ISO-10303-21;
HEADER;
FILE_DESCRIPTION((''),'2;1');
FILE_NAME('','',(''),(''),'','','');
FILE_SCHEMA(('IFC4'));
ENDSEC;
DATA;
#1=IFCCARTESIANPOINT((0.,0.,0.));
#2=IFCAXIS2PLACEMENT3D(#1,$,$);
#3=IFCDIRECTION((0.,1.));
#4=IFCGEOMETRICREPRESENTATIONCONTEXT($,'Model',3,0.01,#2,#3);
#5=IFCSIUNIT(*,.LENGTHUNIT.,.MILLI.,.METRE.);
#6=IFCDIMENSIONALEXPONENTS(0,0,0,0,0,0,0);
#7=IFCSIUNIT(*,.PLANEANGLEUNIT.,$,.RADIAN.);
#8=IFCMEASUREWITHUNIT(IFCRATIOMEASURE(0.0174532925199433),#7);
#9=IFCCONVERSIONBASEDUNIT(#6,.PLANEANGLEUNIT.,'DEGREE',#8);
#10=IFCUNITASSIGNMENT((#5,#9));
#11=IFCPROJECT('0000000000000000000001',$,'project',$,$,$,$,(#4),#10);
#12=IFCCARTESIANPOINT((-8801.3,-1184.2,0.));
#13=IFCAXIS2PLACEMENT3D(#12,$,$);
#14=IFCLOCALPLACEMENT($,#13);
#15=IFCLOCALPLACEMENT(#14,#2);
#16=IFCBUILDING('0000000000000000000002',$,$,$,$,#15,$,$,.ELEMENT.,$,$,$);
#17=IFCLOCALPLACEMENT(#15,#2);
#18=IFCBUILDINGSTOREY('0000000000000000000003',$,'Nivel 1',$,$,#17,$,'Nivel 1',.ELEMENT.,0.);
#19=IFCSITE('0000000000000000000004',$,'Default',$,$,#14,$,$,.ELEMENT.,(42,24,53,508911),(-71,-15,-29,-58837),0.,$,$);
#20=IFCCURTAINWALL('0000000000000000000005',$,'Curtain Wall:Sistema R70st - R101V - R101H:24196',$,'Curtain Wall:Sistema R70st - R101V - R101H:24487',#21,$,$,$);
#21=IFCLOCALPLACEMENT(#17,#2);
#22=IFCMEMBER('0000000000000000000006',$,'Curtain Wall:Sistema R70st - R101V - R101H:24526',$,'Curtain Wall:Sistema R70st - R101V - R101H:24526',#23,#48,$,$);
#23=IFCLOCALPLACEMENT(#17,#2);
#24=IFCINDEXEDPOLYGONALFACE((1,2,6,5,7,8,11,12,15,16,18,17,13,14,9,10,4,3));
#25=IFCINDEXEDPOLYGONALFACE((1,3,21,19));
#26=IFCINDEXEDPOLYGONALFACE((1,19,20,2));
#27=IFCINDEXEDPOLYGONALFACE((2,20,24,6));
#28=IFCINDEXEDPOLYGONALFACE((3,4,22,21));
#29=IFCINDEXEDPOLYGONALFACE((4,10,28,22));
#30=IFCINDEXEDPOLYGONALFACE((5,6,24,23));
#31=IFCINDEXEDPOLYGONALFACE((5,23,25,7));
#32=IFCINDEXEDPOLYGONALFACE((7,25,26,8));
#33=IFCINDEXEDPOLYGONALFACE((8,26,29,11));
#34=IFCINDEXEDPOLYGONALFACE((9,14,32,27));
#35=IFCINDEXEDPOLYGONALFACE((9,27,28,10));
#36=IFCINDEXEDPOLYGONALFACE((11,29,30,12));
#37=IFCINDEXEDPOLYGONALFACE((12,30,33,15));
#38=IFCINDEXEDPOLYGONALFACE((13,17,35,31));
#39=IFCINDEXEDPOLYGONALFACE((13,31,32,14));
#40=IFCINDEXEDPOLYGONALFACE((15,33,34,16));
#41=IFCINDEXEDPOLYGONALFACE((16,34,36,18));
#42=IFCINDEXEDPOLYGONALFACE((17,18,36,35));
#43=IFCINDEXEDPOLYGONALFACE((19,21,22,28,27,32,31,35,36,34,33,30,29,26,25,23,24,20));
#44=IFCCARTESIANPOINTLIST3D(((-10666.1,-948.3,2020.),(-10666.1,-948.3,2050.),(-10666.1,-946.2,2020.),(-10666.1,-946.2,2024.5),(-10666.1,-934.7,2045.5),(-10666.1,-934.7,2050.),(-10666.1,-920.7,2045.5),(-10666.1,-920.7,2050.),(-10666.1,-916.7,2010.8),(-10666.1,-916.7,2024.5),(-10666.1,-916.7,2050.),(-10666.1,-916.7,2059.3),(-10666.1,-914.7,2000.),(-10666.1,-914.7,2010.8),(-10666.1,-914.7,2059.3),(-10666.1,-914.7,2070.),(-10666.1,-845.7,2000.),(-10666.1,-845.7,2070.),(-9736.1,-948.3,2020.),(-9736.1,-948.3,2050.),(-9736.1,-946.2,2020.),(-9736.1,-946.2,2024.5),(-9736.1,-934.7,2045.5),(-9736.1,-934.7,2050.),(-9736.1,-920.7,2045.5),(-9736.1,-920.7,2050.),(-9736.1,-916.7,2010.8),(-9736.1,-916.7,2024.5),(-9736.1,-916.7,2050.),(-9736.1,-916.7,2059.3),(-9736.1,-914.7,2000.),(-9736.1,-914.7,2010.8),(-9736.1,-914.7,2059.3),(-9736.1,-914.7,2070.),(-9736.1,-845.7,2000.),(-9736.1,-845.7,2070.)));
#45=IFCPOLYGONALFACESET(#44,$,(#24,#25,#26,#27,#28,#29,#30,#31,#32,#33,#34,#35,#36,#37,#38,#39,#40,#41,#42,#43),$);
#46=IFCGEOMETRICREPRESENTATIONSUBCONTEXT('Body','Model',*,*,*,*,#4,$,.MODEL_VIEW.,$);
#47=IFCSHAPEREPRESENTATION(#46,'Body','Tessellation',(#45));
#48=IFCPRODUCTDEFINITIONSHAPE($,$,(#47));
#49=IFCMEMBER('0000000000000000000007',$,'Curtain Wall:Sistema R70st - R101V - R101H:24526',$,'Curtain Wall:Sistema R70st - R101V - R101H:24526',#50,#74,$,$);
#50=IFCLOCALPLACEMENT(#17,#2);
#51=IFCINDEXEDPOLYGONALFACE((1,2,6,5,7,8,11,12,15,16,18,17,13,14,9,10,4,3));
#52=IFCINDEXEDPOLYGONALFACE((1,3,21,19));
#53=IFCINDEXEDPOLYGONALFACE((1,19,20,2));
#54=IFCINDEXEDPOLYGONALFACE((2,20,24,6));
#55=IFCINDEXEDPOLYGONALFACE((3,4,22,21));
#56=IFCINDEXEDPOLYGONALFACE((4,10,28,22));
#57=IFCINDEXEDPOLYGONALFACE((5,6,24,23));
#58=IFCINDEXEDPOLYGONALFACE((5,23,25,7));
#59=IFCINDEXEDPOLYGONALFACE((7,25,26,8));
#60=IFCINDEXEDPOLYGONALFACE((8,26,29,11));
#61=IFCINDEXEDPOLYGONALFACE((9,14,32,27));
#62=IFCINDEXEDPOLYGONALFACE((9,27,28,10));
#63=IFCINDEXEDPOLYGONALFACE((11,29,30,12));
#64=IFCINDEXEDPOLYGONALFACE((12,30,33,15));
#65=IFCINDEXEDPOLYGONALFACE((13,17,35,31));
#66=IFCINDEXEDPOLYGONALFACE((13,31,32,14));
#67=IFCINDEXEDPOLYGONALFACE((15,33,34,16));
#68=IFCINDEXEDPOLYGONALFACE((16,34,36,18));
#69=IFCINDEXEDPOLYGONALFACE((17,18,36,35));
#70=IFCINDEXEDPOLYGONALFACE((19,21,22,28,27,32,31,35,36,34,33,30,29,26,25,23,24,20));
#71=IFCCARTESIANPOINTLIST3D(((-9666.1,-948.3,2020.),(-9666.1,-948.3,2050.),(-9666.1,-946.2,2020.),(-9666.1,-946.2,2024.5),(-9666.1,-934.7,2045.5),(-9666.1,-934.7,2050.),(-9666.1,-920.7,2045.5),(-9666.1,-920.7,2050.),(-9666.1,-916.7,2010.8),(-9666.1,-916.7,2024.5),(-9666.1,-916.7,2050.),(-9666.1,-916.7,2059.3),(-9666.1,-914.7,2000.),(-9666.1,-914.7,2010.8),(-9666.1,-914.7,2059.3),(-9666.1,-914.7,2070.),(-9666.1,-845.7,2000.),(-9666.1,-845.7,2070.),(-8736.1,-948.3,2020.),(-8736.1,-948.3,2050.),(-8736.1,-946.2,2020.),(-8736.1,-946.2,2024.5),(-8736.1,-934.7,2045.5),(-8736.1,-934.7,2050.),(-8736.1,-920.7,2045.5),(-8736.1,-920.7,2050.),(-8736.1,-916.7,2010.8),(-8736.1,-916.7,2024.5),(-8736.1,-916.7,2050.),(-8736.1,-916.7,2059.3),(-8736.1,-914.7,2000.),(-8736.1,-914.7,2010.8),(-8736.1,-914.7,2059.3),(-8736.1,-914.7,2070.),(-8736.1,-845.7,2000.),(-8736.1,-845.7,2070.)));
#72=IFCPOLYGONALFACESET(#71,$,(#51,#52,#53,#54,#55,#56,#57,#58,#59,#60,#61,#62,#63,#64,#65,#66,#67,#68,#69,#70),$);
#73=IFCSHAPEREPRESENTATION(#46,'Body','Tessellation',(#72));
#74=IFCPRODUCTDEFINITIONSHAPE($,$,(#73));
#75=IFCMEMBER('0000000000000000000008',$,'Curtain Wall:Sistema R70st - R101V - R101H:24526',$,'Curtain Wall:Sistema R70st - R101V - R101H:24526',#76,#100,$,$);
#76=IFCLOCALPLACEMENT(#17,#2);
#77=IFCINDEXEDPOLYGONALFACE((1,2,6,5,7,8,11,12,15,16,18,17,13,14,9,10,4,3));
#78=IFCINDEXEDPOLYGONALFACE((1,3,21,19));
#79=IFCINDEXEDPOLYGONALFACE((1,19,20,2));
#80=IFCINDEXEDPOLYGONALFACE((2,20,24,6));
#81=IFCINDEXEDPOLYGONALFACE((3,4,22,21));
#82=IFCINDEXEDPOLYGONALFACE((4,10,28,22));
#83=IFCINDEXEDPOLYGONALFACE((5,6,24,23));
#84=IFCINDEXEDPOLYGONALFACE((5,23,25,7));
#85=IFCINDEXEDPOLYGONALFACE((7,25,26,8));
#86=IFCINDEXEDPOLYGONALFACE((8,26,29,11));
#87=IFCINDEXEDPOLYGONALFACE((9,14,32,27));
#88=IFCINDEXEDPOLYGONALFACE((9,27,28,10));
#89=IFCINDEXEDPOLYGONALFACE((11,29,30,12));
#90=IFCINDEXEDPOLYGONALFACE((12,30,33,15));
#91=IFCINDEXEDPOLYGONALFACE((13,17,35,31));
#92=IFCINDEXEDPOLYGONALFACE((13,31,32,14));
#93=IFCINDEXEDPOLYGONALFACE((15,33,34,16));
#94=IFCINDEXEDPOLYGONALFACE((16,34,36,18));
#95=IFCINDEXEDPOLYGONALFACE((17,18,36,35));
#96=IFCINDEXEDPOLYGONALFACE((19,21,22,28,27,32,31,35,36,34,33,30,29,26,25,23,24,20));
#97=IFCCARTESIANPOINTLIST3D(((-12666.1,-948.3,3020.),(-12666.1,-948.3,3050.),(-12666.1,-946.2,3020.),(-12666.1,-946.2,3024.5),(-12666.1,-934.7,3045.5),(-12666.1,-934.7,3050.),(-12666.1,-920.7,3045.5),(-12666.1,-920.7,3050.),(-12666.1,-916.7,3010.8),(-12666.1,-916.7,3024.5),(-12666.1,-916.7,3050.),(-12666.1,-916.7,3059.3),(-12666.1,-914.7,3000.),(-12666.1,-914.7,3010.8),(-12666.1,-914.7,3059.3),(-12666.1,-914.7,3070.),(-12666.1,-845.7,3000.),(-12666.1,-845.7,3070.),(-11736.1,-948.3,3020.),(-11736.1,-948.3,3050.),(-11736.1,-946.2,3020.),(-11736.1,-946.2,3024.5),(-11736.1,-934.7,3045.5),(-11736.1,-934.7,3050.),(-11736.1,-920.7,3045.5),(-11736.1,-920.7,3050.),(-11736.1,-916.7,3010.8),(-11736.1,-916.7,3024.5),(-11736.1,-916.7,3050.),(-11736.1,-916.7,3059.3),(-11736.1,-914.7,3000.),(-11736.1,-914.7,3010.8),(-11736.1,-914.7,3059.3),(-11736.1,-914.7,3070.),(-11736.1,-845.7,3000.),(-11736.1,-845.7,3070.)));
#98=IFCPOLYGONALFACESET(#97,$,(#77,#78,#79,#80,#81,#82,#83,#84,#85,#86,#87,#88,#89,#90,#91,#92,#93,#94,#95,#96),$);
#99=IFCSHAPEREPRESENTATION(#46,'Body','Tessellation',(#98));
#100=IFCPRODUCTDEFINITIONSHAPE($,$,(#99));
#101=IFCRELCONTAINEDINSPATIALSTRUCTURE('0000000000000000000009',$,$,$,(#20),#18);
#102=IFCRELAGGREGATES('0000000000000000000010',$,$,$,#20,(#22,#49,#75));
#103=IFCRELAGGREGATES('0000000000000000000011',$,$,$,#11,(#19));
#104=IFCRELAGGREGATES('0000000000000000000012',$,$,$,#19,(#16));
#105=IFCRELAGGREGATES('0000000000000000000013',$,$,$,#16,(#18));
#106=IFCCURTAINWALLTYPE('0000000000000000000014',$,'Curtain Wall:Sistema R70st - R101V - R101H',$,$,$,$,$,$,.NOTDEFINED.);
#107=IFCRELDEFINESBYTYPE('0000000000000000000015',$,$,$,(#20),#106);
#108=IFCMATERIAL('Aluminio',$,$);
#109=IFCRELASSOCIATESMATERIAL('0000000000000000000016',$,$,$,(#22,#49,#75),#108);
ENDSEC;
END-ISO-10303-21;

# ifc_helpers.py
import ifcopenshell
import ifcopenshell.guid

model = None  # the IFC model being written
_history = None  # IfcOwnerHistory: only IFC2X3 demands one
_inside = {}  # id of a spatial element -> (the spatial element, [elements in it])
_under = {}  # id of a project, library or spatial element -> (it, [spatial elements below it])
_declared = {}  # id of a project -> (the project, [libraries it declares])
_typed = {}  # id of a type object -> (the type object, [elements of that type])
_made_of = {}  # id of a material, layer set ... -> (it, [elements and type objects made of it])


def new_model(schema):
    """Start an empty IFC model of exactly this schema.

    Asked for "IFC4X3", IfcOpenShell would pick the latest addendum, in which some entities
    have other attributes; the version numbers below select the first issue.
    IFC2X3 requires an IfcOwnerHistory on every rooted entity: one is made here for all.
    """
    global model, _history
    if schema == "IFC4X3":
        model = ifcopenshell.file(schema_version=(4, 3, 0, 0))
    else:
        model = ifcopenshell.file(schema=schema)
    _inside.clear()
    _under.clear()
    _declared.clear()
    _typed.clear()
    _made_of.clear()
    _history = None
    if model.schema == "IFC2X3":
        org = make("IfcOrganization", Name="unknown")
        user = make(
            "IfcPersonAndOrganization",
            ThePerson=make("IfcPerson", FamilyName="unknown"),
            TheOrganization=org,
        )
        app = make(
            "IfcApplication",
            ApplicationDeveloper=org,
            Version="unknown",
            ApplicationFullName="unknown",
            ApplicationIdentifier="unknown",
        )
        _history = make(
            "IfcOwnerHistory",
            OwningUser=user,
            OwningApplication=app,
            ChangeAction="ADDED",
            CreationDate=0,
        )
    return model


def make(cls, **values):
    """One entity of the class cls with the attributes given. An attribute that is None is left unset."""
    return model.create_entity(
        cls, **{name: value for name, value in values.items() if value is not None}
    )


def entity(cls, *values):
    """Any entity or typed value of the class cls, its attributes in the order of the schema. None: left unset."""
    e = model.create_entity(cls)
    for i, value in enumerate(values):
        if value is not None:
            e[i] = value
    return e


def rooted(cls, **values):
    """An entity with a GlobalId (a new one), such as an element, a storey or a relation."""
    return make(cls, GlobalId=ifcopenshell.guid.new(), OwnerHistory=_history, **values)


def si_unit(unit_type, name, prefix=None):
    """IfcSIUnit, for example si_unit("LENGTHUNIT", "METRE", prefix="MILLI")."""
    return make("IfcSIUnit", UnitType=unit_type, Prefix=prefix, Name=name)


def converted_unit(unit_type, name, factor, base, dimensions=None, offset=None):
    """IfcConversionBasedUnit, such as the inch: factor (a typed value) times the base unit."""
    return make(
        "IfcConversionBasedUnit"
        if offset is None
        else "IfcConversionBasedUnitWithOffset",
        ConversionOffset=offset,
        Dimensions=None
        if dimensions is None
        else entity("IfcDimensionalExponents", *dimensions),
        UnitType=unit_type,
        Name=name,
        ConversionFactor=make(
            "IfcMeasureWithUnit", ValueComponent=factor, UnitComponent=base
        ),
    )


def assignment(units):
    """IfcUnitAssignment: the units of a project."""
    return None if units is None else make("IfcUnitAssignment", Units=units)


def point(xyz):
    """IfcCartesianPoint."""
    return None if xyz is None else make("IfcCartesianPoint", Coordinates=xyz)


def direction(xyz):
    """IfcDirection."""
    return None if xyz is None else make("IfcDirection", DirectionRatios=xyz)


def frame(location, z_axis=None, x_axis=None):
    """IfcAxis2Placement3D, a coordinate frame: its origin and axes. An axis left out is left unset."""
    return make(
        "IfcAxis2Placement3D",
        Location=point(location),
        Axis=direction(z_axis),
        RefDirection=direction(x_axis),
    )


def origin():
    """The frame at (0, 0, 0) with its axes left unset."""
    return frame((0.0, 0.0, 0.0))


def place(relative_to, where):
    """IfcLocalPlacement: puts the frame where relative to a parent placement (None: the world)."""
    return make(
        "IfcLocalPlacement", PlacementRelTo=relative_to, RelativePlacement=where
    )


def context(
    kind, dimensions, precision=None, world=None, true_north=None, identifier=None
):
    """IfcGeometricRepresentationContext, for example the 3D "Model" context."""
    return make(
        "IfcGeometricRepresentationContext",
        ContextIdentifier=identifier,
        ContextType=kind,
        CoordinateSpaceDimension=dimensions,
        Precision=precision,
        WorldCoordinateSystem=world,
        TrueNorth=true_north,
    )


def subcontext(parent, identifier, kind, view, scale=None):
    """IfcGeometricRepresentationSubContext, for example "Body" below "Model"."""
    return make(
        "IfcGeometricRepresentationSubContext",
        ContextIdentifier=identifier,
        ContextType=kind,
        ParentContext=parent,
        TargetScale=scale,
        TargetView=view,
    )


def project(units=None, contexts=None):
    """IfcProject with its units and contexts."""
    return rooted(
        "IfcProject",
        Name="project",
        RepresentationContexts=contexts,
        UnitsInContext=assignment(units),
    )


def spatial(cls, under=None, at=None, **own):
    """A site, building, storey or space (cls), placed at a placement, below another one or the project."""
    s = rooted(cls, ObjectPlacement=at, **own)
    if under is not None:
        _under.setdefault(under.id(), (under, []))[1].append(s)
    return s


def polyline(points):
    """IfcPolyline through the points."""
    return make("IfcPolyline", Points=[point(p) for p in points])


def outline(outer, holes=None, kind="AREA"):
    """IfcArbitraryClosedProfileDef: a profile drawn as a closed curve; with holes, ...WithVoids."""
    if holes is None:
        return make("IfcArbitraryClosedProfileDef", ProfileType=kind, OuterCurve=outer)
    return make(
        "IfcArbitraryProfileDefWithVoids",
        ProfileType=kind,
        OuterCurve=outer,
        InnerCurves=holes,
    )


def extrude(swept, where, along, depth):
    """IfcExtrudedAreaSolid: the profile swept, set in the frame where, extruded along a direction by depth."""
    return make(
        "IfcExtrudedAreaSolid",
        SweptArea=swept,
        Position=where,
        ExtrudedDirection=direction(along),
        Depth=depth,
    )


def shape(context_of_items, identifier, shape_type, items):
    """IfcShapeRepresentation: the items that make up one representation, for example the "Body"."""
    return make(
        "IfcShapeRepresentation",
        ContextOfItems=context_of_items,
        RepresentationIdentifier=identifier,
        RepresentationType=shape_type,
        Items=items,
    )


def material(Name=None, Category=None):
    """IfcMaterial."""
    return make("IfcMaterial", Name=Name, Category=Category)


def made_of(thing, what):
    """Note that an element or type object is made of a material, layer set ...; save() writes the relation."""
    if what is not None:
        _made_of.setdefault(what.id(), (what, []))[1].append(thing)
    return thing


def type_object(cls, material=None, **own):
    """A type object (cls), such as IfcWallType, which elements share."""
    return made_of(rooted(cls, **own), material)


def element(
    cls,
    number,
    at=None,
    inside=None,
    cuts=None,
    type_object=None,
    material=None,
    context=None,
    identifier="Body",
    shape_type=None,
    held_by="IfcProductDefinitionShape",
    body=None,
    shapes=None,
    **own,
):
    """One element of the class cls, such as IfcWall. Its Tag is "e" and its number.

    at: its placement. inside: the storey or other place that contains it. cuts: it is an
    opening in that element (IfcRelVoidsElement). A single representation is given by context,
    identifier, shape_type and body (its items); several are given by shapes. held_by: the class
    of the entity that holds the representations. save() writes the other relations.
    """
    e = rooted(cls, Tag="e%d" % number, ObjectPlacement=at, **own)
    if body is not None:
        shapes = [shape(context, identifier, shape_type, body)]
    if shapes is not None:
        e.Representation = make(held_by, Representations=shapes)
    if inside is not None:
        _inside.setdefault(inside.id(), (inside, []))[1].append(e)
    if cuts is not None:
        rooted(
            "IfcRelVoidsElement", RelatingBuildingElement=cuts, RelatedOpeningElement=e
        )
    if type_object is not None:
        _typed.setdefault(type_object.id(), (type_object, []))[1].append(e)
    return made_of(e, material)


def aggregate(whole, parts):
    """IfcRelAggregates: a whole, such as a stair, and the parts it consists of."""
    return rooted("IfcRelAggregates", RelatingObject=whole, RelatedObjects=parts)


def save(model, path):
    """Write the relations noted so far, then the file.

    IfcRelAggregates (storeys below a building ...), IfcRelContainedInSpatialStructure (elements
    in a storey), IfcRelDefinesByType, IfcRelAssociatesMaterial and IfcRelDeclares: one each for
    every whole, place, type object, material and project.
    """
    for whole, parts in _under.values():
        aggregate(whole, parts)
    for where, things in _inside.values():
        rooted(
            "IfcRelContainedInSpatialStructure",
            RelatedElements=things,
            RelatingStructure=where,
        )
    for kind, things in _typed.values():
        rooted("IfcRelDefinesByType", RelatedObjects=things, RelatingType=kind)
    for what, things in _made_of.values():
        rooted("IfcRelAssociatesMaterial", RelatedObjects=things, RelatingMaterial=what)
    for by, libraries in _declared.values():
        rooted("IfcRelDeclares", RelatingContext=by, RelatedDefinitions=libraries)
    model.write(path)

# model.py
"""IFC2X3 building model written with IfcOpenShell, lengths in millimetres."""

from ifc_helpers import new_model, entity, si_unit, converted_unit, direction, frame, origin, place, context, subcontext, project, spatial, polyline, outline, extrude, material, type_object, element, aggregate, save


model = new_model("IFC2X3")

# Units and contexts
model_context = context("Model", 3, precision=0.01, world=origin(), true_north=direction((0.0, 1.0)))
body_context = subcontext(model_context, "Body", "Model", "MODEL_VIEW")
ifc_project = project(units=[si_unit("LENGTHUNIT", "METRE", prefix="MILLI"), converted_unit("PLANEANGLEUNIT", "DEGREE", entity("IfcRatioMeasure", 0.0174532925199433), si_unit("PLANEANGLEUNIT", "RADIAN"), dimensions=[0, 0, 0, 0, 0, 0, 0])], contexts=[model_context])

# Site, building, storey
site_placement = place(None, frame((-8801.3, -1184.2, 0.0)))
site = spatial("IfcSite", under=ifc_project, at=site_placement, Name="Default", CompositionType="ELEMENT", RefLatitude=(42, 24, 53, 508911), RefLongitude=(-71, -15, -29, -58837), RefElevation=0.0)
building_placement = place(site_placement, origin())
building = spatial("IfcBuilding", under=site, at=building_placement, CompositionType="ELEMENT")
storey_placement = place(building_placement, origin())
storey = spatial("IfcBuildingStorey", under=building, at=storey_placement, Name="Nivel 1", LongName="Nivel 1", CompositionType="ELEMENT", Elevation=0.0)

# Curtain wall, members
curtain_wall_type = type_object("IfcCurtainWallType", Name="Curtain Wall:Sistema R70st - R101V - R101H", PredefinedType="NOTDEFINED")
curtain_wall_placement = place(storey_placement, origin())
curtain_wall = element("IfcCurtainWall", 1, at=curtain_wall_placement, inside=storey, type_object=curtain_wall_type, Name="Curtain Wall:Sistema R70st - R101V - R101H:24196", ObjectType="Curtain Wall:Sistema R70st - R101V - R101H:24487")
ifc_material = material(Name="Aluminio")
member_1_placement = place(curtain_wall_placement, origin())
member_1 = element("IfcMember", 2, at=member_1_placement, material=ifc_material, Name="Curtain Wall:Sistema R70st - R101V - R101H:24526", ObjectType="Curtain Wall:Sistema R70st - R101V - R101H:24526", context=body_context, shape_type="SweptSolid", body=[
    extrude(outline(polyline([(-33.3, -71.9), (36.7, -71.9), (36.7, -2.9), (25.9, -2.9), (25.9, -0.9), (12.2, -0.9), (12.2, 28.6), (16.7, 28.6), (16.7, 30.7), (-13.3, 30.7), (-13.3, 17.1), (-8.8, 17.1), (-8.8, 3.1), (-13.3, 3.1), (-13.3, -0.9), (-22.6, -0.9), (-22.6, -2.9), (-33.3, -2.9), (-33.3, -71.9)])), frame((-9736.1, -917.6, 2036.7), z_axis=(-1.0, 0.0, 0.0), x_axis=(0.0, 0.0, -1.0)), (0.0, 0.0, 1.0), 930.0),
])
member_2_placement = place(curtain_wall_placement, origin())
member_2 = element("IfcMember", 3, at=member_2_placement, material=ifc_material, Name="Curtain Wall:Sistema R70st - R101V - R101H:24526", ObjectType="Curtain Wall:Sistema R70st - R101V - R101H:24526", context=body_context, shape_type="SweptSolid", body=[
    extrude(outline(polyline([(-33.3, -71.9), (36.7, -71.9), (36.7, -2.9), (25.9, -2.9), (25.9, -0.9), (12.2, -0.9), (12.2, 28.6), (16.7, 28.6), (16.7, 30.7), (-13.3, 30.7), (-13.3, 17.1), (-8.8, 17.1), (-8.8, 3.1), (-13.3, 3.1), (-13.3, -0.9), (-22.6, -0.9), (-22.6, -2.9), (-33.3, -2.9), (-33.3, -71.9)])), frame((-8736.1, -917.6, 2036.7), z_axis=(-1.0, 0.0, 0.0), x_axis=(0.0, 0.0, -1.0)), (0.0, 0.0, 1.0), 930.0),
])
member_3_placement = place(curtain_wall_placement, origin())
member_3 = element("IfcMember", 4, at=member_3_placement, material=ifc_material, Name="Curtain Wall:Sistema R70st - R101V - R101H:24526", ObjectType="Curtain Wall:Sistema R70st - R101V - R101H:24526", context=body_context, shape_type="SweptSolid", body=[
    extrude(outline(polyline([(-33.3, -71.9), (36.7, -71.9), (36.7, -2.9), (25.9, -2.9), (25.9, -0.9), (12.2, -0.9), (12.2, 28.6), (16.7, 28.6), (16.7, 30.7), (-13.3, 30.7), (-13.3, 17.1), (-8.8, 17.1), (-8.8, 3.1), (-13.3, 3.1), (-13.3, -0.9), (-22.6, -0.9), (-22.6, -2.9), (-33.3, -2.9), (-33.3, -71.9)])), frame((-11736.1, -917.6, 3036.7), z_axis=(-1.0, 0.0, 0.0), x_axis=(0.0, 0.0, -1.0)), (0.0, 0.0, 1.0), 930.0),
])
aggregate(curtain_wall, [member_1, member_2, member_3])

save(model, "model.ifc")
